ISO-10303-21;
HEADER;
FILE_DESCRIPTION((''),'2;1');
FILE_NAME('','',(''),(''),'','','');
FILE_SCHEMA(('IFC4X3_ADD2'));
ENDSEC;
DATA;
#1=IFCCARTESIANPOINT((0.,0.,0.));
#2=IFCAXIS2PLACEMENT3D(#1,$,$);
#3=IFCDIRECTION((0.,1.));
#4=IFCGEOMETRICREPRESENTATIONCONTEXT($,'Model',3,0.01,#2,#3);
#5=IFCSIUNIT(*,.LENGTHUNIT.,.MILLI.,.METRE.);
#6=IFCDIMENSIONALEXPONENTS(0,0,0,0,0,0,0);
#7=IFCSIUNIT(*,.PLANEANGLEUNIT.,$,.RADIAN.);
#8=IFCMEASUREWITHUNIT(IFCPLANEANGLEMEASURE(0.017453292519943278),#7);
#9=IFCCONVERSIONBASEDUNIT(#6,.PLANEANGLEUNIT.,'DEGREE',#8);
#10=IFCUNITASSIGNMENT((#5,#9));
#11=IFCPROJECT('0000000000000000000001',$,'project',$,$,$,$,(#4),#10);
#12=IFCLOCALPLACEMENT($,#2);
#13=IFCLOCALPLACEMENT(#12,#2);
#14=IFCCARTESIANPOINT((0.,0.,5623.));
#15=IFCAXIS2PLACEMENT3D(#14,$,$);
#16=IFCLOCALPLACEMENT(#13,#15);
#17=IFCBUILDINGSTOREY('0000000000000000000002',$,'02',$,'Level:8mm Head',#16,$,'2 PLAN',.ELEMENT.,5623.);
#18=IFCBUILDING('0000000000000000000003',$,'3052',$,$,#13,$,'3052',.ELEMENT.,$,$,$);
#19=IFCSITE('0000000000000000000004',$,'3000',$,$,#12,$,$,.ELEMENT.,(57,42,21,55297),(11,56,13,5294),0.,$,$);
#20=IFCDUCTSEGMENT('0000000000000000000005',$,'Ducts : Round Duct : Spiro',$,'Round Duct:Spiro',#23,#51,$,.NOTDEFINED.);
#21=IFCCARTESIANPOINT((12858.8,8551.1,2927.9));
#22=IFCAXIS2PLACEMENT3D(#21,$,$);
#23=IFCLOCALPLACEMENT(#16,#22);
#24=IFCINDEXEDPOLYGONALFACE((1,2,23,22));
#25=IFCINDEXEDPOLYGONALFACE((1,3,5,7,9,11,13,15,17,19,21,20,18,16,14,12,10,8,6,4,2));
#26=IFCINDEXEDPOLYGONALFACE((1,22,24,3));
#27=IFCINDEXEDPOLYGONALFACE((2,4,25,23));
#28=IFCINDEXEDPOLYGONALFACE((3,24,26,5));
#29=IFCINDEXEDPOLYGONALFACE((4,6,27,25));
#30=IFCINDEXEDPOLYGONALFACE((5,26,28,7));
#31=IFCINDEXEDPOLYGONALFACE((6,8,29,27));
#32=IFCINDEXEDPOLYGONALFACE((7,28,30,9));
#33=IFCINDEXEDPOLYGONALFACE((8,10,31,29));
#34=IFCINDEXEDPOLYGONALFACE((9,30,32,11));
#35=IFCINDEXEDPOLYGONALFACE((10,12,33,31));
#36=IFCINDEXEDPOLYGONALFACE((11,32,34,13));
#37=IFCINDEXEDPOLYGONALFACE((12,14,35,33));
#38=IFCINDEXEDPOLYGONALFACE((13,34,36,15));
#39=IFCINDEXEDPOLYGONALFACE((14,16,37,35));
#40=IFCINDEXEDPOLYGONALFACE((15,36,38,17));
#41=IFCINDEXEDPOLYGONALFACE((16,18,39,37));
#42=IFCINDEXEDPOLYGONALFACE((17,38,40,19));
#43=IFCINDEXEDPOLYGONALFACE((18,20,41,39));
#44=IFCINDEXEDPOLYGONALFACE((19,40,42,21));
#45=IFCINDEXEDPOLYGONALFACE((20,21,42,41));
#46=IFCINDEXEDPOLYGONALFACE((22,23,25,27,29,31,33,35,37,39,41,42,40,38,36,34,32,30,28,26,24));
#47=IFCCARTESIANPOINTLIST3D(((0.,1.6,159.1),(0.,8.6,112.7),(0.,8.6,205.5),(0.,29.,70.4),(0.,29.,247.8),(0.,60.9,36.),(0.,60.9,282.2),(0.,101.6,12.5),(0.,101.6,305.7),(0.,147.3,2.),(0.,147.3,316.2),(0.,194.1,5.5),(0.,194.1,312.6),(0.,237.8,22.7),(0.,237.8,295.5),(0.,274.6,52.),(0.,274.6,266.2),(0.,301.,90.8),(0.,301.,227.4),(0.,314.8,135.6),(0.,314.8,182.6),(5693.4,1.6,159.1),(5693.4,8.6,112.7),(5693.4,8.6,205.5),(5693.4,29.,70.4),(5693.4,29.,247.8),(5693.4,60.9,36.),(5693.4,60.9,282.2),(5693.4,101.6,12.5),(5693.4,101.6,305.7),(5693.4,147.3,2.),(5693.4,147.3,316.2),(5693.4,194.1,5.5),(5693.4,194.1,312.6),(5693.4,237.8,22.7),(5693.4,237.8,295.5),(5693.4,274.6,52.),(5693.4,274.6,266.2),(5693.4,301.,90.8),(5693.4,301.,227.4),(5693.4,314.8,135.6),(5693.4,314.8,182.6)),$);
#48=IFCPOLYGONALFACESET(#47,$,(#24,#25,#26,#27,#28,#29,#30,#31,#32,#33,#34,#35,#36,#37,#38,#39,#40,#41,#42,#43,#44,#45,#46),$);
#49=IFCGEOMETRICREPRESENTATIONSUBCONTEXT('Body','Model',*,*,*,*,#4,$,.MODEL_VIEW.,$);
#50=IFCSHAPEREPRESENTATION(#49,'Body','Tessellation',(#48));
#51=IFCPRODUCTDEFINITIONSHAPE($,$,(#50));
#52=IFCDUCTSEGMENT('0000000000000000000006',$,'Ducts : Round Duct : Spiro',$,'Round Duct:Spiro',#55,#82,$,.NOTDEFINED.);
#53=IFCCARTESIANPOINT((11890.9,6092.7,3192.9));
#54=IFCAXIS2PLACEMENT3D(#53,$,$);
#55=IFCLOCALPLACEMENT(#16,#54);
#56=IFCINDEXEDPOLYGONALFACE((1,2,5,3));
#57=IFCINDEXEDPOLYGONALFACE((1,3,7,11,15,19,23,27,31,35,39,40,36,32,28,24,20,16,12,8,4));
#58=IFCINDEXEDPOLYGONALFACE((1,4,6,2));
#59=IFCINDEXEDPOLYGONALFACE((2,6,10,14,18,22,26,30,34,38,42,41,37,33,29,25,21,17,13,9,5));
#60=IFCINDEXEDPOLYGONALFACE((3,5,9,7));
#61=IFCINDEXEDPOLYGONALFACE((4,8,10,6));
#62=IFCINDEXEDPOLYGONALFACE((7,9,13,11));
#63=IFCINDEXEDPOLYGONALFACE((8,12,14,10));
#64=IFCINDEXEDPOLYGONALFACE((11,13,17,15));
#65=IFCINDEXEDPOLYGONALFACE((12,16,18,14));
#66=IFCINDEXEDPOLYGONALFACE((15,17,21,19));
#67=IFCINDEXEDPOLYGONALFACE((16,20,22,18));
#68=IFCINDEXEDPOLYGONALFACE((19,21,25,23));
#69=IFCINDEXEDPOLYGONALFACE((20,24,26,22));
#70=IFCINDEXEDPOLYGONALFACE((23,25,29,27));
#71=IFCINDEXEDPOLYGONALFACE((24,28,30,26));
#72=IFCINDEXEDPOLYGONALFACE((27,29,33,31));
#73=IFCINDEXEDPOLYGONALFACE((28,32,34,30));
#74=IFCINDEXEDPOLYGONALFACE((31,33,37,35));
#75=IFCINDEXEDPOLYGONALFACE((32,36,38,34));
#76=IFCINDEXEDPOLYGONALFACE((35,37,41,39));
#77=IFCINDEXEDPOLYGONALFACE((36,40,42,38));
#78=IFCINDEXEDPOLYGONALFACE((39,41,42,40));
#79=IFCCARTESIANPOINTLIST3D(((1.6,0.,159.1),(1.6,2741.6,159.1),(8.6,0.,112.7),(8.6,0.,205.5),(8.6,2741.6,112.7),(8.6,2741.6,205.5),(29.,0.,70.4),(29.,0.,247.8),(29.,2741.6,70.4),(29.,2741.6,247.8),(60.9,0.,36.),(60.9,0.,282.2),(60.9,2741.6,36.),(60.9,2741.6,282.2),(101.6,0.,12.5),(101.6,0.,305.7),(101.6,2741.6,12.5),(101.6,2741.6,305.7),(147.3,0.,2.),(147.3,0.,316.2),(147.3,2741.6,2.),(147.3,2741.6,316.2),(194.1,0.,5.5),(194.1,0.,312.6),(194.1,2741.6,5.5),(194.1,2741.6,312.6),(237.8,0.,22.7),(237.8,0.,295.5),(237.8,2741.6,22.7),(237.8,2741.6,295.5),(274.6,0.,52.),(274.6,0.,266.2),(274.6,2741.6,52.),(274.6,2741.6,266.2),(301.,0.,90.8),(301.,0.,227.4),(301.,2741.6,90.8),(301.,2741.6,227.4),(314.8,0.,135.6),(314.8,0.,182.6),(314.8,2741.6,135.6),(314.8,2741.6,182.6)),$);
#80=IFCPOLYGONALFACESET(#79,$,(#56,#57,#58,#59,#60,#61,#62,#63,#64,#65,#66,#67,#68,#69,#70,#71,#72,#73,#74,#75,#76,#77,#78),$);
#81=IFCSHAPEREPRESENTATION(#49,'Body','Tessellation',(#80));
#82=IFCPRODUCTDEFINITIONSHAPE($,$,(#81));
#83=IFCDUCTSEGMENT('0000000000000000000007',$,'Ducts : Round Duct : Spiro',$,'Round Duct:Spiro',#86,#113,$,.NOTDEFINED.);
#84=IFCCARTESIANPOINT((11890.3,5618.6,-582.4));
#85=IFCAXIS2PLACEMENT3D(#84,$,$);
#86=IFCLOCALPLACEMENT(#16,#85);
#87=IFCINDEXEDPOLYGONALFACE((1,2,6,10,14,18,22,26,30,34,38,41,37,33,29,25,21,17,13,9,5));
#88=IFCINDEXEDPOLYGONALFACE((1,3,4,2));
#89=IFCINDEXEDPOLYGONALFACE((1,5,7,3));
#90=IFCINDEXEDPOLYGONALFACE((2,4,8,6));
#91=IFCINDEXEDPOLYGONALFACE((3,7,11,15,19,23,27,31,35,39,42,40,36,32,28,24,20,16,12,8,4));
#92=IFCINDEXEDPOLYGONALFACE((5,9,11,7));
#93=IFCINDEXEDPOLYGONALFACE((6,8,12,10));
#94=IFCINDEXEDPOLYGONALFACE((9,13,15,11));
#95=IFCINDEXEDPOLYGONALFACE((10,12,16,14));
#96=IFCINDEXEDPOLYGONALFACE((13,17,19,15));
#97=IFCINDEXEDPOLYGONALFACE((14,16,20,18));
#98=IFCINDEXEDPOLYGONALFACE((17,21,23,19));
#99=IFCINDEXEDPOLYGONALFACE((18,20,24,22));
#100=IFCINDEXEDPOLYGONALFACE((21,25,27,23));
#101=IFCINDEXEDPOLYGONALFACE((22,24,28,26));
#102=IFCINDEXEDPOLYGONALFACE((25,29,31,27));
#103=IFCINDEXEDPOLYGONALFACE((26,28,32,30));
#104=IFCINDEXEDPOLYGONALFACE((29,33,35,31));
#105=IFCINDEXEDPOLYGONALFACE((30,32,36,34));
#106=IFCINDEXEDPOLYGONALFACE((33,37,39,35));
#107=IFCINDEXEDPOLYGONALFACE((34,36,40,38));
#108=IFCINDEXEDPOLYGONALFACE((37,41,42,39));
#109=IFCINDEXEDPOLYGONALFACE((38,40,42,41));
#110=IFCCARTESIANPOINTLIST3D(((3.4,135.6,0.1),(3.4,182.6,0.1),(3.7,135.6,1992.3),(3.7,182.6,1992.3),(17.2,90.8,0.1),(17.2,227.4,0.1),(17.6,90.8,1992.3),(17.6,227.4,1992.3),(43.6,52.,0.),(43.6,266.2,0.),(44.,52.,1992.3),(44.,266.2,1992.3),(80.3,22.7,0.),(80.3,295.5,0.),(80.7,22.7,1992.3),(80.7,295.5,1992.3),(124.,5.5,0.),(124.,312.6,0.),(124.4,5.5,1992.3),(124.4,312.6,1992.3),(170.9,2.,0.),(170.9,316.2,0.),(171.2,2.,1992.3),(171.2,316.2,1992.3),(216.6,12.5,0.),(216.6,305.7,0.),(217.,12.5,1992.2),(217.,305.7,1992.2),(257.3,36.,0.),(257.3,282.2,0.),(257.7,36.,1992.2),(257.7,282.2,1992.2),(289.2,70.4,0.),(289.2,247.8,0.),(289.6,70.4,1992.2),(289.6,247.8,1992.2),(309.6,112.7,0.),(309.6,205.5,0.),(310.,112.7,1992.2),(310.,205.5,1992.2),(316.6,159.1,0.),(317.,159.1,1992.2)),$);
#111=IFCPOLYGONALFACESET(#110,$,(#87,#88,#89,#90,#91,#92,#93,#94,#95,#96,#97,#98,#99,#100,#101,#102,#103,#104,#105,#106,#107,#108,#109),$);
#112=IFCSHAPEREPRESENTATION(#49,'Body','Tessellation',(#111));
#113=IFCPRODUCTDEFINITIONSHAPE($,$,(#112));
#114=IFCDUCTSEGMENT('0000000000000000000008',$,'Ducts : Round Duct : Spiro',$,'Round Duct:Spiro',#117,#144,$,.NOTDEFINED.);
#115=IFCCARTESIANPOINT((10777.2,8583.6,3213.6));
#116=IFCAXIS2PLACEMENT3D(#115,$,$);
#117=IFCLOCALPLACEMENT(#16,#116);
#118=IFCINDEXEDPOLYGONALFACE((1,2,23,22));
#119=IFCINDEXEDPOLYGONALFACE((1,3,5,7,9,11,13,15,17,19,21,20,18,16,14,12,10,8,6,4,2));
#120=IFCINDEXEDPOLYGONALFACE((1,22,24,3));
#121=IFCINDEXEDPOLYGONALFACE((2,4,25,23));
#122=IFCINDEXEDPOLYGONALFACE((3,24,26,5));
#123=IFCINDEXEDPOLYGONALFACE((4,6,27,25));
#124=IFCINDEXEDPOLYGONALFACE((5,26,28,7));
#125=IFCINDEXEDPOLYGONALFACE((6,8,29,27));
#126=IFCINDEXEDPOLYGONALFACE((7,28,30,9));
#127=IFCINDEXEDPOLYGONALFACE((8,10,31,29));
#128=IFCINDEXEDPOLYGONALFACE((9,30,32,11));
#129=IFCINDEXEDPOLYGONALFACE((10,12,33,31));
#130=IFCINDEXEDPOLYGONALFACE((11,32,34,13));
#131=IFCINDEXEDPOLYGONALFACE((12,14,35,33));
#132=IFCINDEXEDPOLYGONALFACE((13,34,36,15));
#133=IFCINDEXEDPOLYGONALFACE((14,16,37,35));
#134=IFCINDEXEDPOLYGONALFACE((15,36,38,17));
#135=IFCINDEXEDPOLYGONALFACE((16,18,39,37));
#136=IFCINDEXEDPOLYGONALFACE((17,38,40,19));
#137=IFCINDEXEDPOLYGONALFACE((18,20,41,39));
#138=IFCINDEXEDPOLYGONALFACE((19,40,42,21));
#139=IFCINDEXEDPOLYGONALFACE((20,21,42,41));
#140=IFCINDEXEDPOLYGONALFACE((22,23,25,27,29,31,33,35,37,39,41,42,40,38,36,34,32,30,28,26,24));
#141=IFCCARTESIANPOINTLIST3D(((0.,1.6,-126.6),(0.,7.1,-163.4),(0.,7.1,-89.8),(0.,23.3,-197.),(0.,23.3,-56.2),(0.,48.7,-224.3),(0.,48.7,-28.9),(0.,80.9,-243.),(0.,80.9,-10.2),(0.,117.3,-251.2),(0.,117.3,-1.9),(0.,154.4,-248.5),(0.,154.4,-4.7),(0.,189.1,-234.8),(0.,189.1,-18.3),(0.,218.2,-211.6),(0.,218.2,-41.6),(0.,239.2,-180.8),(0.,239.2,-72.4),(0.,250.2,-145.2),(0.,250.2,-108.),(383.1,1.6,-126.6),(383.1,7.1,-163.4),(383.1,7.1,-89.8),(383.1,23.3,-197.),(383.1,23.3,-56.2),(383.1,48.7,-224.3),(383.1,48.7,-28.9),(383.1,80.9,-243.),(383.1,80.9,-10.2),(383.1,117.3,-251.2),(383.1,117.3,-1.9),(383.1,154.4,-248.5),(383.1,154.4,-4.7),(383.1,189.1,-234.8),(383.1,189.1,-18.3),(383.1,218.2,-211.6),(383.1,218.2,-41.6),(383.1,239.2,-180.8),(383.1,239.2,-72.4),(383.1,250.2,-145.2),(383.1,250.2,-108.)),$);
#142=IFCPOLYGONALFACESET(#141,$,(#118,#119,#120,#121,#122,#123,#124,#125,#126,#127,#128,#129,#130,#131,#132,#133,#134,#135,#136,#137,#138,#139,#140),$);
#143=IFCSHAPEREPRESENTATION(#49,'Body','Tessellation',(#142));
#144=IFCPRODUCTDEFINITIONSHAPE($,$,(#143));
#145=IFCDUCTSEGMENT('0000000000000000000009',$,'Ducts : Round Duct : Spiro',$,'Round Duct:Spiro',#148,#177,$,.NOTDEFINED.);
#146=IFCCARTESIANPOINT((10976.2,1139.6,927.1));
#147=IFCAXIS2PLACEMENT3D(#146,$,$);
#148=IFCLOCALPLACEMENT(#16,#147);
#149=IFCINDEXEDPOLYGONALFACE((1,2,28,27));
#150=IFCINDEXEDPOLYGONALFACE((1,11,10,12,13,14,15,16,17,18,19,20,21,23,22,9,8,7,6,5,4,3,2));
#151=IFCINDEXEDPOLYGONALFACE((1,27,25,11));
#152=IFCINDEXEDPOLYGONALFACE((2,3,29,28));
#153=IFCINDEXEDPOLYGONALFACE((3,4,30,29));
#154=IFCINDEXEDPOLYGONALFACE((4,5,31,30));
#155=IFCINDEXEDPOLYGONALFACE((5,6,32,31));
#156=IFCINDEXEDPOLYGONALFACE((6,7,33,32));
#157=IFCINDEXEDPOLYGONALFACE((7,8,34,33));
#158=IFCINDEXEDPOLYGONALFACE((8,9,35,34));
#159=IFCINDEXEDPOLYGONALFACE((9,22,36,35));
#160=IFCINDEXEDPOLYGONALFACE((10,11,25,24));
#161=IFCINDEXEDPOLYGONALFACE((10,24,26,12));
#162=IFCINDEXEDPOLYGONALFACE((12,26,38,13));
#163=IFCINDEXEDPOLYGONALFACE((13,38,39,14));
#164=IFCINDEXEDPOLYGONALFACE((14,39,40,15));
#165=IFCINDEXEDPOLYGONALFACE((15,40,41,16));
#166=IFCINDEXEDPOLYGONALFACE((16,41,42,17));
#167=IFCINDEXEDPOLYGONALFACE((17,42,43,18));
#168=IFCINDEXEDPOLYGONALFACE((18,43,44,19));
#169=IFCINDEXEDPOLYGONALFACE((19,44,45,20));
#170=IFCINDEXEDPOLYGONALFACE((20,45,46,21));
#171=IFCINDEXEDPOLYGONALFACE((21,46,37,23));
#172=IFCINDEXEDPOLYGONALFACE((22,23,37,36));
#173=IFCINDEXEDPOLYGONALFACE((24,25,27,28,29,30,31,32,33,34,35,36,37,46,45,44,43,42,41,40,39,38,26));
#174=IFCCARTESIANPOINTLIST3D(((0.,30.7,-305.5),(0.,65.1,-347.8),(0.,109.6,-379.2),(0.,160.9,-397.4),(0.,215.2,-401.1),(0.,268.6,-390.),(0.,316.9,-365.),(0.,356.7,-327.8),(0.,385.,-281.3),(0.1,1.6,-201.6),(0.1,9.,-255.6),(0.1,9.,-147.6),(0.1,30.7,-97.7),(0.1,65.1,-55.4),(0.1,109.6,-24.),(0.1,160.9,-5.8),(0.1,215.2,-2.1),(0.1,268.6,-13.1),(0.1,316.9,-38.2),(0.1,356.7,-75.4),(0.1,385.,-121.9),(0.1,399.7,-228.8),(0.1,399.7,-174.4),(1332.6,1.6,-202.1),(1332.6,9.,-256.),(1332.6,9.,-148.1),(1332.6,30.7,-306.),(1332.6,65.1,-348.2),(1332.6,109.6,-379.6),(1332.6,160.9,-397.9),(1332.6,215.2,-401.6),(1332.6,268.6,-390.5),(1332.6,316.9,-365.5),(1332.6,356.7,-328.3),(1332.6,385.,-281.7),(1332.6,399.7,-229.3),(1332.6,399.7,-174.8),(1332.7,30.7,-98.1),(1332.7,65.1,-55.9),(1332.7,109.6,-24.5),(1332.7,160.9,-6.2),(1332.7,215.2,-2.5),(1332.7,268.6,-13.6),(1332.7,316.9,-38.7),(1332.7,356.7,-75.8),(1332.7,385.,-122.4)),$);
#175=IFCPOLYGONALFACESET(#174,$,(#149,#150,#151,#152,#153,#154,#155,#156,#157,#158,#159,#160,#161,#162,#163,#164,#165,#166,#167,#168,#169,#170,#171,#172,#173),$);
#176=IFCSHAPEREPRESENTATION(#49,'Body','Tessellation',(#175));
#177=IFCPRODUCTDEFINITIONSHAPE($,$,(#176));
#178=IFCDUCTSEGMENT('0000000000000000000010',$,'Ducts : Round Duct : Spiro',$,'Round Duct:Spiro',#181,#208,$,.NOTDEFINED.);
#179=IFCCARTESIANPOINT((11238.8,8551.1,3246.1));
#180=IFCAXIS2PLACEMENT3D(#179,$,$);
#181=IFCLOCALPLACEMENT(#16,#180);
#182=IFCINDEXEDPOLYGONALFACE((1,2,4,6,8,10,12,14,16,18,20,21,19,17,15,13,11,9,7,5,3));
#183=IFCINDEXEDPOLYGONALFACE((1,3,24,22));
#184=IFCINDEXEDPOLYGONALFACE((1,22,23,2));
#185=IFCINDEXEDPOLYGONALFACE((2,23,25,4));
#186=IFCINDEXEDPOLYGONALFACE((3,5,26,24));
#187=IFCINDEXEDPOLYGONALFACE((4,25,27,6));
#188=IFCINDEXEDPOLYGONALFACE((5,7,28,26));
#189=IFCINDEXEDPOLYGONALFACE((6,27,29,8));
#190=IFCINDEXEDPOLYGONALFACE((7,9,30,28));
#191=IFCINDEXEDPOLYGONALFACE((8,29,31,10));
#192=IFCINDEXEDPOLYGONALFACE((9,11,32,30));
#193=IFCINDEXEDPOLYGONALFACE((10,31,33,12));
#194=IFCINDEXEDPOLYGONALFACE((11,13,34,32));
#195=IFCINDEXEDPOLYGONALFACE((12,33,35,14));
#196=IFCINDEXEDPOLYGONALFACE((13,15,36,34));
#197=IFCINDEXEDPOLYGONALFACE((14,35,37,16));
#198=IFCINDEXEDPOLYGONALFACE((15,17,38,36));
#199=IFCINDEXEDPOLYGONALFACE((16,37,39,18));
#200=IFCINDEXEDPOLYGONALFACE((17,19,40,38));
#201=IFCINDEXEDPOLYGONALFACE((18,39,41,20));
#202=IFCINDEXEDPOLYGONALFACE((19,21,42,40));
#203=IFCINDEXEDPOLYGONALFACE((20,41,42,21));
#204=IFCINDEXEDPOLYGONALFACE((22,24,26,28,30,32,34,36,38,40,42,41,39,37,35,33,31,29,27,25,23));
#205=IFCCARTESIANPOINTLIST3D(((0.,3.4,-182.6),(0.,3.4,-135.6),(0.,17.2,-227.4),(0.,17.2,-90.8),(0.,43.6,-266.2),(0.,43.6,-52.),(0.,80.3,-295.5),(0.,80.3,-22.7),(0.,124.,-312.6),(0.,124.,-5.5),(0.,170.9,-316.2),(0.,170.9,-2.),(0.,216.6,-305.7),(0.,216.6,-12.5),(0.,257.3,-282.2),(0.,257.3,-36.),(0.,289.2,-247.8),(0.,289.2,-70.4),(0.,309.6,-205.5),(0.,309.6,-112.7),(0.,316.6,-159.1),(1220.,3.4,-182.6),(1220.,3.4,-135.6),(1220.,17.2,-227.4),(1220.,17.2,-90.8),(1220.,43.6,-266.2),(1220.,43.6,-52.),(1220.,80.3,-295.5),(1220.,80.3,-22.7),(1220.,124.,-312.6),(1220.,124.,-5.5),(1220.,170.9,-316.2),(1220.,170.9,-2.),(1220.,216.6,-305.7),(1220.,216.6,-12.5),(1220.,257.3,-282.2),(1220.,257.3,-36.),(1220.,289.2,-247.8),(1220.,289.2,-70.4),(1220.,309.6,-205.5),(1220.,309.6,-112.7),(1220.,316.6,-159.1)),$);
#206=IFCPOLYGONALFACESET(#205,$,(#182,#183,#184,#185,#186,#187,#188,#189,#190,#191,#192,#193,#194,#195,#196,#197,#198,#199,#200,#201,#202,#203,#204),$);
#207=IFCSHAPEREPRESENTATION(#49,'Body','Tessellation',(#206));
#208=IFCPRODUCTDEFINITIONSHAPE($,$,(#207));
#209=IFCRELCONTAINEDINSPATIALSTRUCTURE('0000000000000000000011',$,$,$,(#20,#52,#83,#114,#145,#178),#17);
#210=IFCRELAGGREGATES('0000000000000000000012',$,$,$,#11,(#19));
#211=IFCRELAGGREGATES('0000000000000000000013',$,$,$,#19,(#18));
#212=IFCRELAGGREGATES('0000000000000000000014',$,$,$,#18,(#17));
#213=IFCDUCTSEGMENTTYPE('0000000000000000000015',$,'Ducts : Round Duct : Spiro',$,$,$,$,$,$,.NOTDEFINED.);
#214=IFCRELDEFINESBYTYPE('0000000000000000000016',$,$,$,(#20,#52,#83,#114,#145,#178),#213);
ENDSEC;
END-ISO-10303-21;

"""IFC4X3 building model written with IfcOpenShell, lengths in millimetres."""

from ifc_helpers import new_model, entity, si_unit, converted_unit, direction, frame, frame_2d, origin, origin_2d_with_axis, place, context, subcontext, project, spatial, circle, extrude, type_object, element, save


model = new_model("IFC4X3")

# Units and contexts
model_context = context("Model", 3, precision=0.01, world=origin(), true_north=direction((0.0, 1.0)))
body_context = subcontext(model_context, "Body", "Model", "MODEL_VIEW")
ifc_project = project(units=[si_unit("LENGTHUNIT", "METRE", prefix="MILLI"), converted_unit("PLANEANGLEUNIT", "DEGREE", entity("IfcPlaneAngleMeasure", 0.017453292519943278), si_unit("PLANEANGLEUNIT", "RADIAN"), dimensions=[0, 0, 0, 0, 0, 0, 0])], contexts=[model_context])

# Site, building, storey
site_placement = place(None, origin())
site = spatial("IfcSite", under=ifc_project, at=site_placement, Name="3000", CompositionType="ELEMENT", RefLatitude=(57, 42, 21, 55297), RefLongitude=(11, 56, 13, 5294), RefElevation=0.0)
building_placement = place(site_placement, origin())
building = spatial("IfcBuilding", under=site, at=building_placement, Name="3052", LongName="3052", CompositionType="ELEMENT")
storey_placement = place(building_placement, frame((0.0, 0.0, 5623.0)))
storey = spatial("IfcBuildingStorey", under=building, at=storey_placement, Name="02", ObjectType="Level:8mm Head", LongName="2 PLAN", CompositionType="ELEMENT", Elevation=5623.0)

# Duct segments
duct_segment_type = type_object("IfcDuctSegmentType", Name="Ducts : Round Duct : Spiro", PredefinedType="NOTDEFINED")
duct_segment_1_placement = place(storey_placement, frame((12858.8, 8551.1, 2927.9)))
element("IfcDuctSegment", 1, at=duct_segment_1_placement, inside=storey, type_object=duct_segment_type, Name="Ducts : Round Duct : Spiro", ObjectType="Round Duct:Spiro", PredefinedType="NOTDEFINED", context=body_context, shape_type="SweptSolid", body=[
    extrude(circle(Radius=157.5, at=frame_2d((0.0, 0.0), x_axis=(1.0, 0.0))), frame((0.0, 159.1, 159.1), z_axis=(1.0, 0.0, 0.0), x_axis=(0.0, -1.0, 0.0)), (0.0, 0.0, 1.0), 5693.4),
])
duct_segment_2_placement = place(storey_placement, frame((11890.9, 6092.7, 3192.9)))
element("IfcDuctSegment", 2, at=duct_segment_2_placement, inside=storey, type_object=duct_segment_type, Name="Ducts : Round Duct : Spiro", ObjectType="Round Duct:Spiro", PredefinedType="NOTDEFINED", context=body_context, shape_type="SweptSolid", body=[
    extrude(circle(Radius=157.5, at=frame_2d((0.0, 0.0), x_axis=(1.0, 0.0))), frame((159.1, 0.0, 159.1), z_axis=(0.0, 1.0, 0.0), x_axis=(-1.0, 0.0, 0.0)), (0.0, 0.0, 1.0), 2741.6),
])
duct_segment_3_placement = place(storey_placement, frame((11890.3, 5618.6, -582.4)))
element("IfcDuctSegment", 3, at=duct_segment_3_placement, inside=storey, type_object=duct_segment_type, Name="Ducts : Round Duct : Spiro", ObjectType="Round Duct:Spiro", PredefinedType="NOTDEFINED", context=body_context, shape_type="SweptSolid", body=[
    extrude(circle(Radius=157.5, at=origin_2d_with_axis()), frame((159.1, 159.1, 0.0), z_axis=(0.000181, 0.0, 1.0), x_axis=(1.0, 0.0, -0.000181)), (0.0, 0.0, 1.0), 1992.2),
])
duct_segment_4_placement = place(storey_placement, frame((10777.2, 8583.6, 3213.6)))
element("IfcDuctSegment", 4, at=duct_segment_4_placement, inside=storey, type_object=duct_segment_type, Name="Ducts : Round Duct : Spiro", ObjectType="Round Duct:Spiro", PredefinedType="NOTDEFINED", context=body_context, shape_type="SweptSolid", body=[
    extrude(circle(Radius=125.0, at=frame_2d((0.0, 0.0), x_axis=(1.0, 0.0))), frame((0.0, 126.6, -126.6), z_axis=(1.0, 0.0, 0.0), x_axis=(0.0, -1.0, 0.0)), (0.0, 0.0, 1.0), 383.1),
])
duct_segment_5_placement = place(storey_placement, frame((10976.2, 1139.6, 927.1)))
element("IfcDuctSegment", 5, at=duct_segment_5_placement, inside=storey, type_object=duct_segment_type, Name="Ducts : Round Duct : Spiro", ObjectType="Round Duct:Spiro", PredefinedType="NOTDEFINED", context=body_context, shape_type="SweptSolid", body=[
    extrude(circle(Radius=200.0, at=frame_2d((0.0, 0.0), x_axis=(1.0, 0.0))), frame((1332.6, 201.6, -202.1), z_axis=(-1.0, 0.0, 0.000349), x_axis=(0.0, -1.0, 0.0)), (0.0, 0.0, 1.0), 1332.6),
])
duct_segment_6_placement = place(storey_placement, frame((11238.8, 8551.1, 3246.1)))
element("IfcDuctSegment", 6, at=duct_segment_6_placement, inside=storey, type_object=duct_segment_type, Name="Ducts : Round Duct : Spiro", ObjectType="Round Duct:Spiro", PredefinedType="NOTDEFINED", context=body_context, shape_type="SweptSolid", body=[
    extrude(circle(Radius=157.5, at=frame_2d((0.0, 0.0), x_axis=(1.0, 0.0))), frame((0.0, 159.1, -159.1), z_axis=(1.0, 0.0, 0.0), x_axis=(0.0, 1.0, 0.0)), (0.0, 0.0, 1.0), 1220.0),
])

save(model, "model.ifc")
